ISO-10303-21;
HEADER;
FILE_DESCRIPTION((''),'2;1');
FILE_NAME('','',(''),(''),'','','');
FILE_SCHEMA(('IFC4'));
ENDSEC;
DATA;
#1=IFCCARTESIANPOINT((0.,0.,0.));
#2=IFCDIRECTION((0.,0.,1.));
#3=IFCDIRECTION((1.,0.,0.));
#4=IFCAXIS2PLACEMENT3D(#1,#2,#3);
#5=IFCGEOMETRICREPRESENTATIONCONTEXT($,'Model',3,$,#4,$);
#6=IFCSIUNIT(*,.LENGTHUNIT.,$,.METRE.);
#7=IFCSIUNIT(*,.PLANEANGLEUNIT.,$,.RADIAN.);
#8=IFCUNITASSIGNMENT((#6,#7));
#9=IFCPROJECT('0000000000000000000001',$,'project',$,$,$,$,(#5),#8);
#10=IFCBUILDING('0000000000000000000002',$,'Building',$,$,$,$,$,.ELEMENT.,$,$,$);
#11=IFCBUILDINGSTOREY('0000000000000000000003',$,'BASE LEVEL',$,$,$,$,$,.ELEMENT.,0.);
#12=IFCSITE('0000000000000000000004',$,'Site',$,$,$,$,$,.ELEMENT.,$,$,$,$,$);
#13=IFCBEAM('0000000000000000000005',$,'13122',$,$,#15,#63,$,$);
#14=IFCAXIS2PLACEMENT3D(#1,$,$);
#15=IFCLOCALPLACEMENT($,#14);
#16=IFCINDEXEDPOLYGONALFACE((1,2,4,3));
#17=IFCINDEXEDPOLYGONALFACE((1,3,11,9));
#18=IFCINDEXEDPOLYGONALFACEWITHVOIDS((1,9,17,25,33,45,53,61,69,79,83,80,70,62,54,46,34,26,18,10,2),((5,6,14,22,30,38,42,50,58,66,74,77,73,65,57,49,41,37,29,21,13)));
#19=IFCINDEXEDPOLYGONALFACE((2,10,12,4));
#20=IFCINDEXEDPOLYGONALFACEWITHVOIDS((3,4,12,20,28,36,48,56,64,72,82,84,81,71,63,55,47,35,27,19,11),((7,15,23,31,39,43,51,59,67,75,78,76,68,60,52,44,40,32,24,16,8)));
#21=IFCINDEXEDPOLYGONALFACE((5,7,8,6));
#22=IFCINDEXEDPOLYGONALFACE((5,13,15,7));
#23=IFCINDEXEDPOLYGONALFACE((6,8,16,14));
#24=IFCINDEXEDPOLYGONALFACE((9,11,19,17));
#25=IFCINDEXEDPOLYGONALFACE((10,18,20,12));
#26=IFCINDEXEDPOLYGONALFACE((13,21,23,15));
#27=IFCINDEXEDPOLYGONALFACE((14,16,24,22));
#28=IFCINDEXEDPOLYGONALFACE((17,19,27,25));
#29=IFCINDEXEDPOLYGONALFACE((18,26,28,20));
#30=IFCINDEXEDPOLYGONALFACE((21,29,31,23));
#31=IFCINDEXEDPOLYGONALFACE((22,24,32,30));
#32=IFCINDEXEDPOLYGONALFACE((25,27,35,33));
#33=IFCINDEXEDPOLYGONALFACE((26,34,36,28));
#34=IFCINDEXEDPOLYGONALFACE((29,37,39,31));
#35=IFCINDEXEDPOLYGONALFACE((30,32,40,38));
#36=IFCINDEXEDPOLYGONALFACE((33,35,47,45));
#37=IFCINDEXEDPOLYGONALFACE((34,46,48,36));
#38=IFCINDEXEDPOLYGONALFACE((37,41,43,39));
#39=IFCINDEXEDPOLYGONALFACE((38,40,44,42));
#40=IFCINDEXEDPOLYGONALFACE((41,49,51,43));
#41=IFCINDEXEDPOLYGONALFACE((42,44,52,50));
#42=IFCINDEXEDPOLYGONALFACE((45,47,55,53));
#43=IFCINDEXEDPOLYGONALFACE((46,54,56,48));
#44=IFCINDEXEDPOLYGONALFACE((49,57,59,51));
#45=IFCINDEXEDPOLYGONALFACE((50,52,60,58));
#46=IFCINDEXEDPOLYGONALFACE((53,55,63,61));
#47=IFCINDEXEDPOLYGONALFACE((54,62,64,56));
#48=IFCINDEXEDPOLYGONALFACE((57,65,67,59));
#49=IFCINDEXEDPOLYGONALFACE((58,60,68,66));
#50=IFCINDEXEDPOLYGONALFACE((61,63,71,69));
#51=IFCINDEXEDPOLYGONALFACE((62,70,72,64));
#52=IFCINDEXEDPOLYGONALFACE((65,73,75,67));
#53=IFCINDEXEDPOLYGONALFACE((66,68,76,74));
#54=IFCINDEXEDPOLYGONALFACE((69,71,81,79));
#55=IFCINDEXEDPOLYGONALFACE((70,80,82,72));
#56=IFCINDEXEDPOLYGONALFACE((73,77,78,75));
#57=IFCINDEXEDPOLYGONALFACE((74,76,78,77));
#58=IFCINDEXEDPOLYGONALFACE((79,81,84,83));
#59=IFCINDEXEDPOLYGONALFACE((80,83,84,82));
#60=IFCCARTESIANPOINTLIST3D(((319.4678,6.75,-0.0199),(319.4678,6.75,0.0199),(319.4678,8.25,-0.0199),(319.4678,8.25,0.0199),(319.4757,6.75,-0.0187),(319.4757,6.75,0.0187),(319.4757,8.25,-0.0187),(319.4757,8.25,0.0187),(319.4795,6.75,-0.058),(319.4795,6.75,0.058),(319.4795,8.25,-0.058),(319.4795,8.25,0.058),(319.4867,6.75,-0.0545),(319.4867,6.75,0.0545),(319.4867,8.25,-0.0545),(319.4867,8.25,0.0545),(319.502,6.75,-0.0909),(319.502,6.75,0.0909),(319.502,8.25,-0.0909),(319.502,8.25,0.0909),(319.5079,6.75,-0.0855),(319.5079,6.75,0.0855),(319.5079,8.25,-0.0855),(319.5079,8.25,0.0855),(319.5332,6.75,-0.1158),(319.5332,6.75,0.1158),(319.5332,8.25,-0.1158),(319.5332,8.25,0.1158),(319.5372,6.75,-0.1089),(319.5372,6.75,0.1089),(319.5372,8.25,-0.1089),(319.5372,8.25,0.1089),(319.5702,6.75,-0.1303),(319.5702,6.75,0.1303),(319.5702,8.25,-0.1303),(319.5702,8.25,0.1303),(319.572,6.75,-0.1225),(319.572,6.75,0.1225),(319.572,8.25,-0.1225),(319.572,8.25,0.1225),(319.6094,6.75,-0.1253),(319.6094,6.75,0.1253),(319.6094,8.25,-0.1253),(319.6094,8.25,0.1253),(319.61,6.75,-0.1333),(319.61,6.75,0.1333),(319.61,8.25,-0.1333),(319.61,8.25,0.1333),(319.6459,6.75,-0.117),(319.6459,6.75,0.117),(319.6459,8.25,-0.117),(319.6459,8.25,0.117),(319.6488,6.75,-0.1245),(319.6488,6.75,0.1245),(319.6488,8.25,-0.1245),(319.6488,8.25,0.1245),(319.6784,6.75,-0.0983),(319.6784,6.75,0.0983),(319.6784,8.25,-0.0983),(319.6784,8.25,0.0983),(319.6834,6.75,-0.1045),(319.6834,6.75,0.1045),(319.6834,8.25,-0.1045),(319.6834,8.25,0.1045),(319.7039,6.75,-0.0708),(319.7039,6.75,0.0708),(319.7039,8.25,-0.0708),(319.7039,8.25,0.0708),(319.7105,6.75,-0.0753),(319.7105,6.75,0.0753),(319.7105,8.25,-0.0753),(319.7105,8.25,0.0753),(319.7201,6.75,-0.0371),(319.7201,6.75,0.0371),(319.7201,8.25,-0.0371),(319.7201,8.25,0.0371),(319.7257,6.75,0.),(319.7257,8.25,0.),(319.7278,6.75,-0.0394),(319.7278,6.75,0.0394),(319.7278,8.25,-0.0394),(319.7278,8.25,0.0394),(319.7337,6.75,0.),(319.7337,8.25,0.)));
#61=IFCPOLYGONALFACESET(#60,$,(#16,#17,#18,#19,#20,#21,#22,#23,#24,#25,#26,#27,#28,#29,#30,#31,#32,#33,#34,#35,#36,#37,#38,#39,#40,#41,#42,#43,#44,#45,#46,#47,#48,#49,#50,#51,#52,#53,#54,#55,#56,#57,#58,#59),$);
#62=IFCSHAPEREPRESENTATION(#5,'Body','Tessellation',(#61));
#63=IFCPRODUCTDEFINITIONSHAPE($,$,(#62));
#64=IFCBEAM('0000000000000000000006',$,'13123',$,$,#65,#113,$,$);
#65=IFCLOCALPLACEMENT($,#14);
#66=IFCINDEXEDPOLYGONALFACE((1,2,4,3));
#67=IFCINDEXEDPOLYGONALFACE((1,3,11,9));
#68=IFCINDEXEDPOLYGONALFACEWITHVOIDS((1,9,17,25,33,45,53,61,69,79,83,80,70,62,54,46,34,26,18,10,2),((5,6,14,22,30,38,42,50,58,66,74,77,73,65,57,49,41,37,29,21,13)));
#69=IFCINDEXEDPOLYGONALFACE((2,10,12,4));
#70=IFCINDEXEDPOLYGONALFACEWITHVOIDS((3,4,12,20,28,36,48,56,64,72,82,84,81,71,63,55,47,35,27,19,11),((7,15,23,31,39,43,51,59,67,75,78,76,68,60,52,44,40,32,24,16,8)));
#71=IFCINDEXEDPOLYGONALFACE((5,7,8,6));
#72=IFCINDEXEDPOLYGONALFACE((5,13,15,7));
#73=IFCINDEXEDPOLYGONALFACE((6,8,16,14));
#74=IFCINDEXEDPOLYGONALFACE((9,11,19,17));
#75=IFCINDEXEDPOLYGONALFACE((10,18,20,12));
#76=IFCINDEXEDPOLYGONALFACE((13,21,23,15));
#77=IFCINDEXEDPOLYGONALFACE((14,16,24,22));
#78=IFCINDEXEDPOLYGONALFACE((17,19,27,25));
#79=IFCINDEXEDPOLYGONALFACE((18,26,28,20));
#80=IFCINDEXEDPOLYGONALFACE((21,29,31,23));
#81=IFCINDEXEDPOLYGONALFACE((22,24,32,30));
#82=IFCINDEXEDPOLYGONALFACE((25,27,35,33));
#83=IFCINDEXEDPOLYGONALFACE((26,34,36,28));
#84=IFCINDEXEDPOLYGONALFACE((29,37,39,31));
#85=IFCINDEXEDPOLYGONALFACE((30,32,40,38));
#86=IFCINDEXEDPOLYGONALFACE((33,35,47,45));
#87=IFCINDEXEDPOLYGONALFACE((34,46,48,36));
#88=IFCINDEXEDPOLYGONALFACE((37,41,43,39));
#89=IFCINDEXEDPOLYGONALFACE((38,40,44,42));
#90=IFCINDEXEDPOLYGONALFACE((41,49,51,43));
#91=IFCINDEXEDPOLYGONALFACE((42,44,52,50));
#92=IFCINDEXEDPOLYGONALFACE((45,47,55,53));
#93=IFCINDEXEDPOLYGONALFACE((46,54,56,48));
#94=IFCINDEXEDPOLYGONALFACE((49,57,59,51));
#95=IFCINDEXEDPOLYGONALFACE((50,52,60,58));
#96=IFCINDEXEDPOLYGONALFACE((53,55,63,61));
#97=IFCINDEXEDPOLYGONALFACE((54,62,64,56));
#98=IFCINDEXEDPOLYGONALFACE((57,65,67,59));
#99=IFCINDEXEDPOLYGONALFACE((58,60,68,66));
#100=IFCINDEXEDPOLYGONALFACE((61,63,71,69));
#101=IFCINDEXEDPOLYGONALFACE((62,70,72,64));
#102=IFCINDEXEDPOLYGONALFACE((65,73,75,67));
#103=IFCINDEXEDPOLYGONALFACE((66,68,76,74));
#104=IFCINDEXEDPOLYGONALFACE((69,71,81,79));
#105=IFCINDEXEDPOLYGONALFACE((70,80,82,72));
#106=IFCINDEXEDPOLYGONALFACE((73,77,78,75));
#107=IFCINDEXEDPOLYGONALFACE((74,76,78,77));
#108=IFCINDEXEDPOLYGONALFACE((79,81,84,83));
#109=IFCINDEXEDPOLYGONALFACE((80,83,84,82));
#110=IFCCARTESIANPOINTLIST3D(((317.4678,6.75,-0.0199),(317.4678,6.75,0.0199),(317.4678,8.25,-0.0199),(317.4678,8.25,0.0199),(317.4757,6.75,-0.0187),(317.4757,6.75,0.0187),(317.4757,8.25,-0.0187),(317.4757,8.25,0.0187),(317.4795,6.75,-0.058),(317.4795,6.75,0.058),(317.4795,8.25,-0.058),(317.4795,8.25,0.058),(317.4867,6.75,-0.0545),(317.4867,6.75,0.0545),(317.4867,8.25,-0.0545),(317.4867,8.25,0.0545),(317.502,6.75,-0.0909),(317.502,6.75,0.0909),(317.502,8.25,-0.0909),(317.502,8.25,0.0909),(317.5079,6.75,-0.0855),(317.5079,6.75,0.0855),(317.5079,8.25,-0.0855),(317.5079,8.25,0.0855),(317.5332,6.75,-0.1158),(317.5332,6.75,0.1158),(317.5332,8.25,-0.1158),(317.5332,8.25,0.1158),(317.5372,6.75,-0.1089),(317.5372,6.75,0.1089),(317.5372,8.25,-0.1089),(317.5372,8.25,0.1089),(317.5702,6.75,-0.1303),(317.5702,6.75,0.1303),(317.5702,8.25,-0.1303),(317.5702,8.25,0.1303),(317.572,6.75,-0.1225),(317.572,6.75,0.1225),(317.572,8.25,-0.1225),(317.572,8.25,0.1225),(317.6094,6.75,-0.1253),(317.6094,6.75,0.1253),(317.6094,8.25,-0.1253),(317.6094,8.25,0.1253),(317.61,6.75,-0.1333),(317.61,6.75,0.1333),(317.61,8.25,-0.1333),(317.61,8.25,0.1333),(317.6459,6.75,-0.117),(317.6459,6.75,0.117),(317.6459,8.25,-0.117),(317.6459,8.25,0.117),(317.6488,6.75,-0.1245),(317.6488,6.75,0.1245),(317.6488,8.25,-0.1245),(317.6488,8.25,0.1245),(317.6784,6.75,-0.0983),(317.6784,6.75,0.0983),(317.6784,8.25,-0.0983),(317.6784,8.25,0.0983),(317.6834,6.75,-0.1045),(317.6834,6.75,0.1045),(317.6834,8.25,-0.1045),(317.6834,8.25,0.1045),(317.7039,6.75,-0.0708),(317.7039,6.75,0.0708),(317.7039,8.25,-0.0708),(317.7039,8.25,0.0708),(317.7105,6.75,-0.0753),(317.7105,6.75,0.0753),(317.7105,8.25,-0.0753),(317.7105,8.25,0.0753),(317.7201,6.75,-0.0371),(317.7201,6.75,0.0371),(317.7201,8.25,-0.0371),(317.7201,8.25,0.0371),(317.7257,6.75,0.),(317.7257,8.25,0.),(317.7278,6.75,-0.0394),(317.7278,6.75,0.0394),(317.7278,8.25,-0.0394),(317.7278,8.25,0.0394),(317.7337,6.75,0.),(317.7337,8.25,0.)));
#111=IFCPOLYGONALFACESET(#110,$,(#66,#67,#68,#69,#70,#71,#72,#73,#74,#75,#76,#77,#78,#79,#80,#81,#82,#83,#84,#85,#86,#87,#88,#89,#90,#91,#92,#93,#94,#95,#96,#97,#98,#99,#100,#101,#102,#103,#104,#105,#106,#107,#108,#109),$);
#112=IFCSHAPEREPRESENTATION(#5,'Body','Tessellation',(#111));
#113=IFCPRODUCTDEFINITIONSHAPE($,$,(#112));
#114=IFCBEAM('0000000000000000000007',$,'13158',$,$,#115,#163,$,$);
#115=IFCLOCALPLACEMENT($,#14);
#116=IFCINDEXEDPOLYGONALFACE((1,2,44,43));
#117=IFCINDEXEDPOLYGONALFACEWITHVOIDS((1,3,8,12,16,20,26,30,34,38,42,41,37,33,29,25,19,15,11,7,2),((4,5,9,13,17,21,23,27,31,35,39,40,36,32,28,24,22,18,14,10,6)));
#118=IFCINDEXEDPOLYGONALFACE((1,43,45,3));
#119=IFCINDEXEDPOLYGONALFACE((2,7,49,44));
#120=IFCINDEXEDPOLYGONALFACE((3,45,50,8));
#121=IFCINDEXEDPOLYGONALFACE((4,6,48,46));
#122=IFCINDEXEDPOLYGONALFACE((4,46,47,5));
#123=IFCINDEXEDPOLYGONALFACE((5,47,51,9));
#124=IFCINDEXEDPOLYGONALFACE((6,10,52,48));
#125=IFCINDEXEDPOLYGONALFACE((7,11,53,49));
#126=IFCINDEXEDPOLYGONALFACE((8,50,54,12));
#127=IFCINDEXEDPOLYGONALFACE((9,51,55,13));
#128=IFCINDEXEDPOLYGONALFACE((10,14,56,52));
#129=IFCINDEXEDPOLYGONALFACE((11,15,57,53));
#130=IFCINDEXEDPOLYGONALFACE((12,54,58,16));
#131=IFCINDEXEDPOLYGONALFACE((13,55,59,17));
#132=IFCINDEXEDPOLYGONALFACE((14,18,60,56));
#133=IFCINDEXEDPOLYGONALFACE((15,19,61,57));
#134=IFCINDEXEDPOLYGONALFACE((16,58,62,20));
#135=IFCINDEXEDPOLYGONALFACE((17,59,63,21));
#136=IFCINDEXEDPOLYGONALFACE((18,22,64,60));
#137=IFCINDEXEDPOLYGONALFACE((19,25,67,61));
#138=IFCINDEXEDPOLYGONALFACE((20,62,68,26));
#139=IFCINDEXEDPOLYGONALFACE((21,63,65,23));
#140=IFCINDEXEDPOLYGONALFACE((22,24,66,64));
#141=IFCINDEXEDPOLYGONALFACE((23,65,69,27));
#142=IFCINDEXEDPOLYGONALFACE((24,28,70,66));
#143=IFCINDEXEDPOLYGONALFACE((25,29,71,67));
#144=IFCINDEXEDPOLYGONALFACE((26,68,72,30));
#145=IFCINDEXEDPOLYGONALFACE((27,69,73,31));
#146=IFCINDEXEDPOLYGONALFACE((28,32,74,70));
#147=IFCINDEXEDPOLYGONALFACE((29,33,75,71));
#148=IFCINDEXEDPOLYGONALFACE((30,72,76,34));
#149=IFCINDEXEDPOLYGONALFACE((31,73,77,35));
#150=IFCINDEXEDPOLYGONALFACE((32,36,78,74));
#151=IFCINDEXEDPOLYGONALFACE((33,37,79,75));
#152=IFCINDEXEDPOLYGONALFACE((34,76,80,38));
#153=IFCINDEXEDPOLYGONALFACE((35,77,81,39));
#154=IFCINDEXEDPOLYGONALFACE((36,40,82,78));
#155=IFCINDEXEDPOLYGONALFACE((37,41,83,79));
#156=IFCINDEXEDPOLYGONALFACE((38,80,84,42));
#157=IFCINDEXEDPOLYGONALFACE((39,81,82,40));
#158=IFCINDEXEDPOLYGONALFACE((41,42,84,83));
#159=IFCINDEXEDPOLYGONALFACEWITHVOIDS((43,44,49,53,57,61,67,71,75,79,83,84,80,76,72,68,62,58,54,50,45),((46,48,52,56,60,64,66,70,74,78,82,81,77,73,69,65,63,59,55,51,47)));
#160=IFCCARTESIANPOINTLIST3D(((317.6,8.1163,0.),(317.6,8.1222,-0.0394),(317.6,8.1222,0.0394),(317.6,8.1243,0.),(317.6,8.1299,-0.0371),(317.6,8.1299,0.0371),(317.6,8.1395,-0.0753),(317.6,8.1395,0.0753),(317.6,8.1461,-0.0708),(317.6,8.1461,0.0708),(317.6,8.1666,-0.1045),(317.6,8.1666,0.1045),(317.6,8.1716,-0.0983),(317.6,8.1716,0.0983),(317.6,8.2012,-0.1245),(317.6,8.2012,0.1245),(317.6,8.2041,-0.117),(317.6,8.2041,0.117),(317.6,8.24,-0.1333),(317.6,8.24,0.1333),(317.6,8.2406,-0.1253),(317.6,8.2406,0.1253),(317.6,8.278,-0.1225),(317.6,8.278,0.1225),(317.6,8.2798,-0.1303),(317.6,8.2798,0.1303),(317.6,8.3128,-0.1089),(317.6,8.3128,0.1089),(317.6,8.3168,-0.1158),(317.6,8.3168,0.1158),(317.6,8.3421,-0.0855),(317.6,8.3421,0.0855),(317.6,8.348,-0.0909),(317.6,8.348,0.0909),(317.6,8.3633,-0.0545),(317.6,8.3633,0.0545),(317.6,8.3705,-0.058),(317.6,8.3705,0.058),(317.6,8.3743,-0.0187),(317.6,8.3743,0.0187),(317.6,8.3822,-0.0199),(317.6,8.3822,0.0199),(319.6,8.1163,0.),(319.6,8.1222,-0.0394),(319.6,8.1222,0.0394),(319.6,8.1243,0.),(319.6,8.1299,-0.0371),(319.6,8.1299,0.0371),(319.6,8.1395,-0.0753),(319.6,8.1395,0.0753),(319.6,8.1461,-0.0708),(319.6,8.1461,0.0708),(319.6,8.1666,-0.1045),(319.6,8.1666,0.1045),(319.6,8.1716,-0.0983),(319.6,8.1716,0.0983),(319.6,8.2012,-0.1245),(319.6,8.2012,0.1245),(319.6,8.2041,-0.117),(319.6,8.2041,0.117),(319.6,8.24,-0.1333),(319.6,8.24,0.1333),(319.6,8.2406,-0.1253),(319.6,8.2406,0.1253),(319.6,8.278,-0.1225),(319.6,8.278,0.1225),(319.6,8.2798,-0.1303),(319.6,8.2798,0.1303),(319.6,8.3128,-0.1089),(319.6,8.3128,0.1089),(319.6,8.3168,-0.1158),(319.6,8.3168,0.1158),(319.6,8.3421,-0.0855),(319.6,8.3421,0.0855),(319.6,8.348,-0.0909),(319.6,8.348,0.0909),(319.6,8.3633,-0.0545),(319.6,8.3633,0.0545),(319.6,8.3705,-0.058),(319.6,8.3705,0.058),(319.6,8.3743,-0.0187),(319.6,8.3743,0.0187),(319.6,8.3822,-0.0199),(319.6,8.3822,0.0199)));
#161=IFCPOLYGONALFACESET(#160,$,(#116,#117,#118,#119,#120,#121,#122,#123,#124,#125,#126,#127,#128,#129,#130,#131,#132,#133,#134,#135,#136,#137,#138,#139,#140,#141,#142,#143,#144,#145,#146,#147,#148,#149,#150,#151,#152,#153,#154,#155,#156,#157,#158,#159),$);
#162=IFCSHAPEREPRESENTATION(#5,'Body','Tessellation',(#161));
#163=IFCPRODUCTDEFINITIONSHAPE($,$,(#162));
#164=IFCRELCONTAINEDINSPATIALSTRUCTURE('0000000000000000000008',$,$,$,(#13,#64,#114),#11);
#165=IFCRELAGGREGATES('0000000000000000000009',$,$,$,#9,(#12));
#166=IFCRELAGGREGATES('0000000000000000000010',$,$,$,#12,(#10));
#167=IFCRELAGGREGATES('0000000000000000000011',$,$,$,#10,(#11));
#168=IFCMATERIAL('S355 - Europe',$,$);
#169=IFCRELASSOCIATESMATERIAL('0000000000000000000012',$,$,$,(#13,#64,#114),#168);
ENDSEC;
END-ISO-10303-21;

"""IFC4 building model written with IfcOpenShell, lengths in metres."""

from ifc_helpers import new_model, si_unit, frame, origin_with_axes, origin_2d_with_axis, place, context, project, spatial, hollow_circle, extrude, material, material_profile, profile_set, profile_usage, element, save


model = new_model("IFC4")

# Units and contexts
model_context = context("Model", 3, world=origin_with_axes())
ifc_project = project(units=[si_unit("LENGTHUNIT", "METRE"), si_unit("PLANEANGLEUNIT", "RADIAN")], contexts=[model_context])

# Site, building, storey
site = spatial("IfcSite", under=ifc_project, Name="Site", CompositionType="ELEMENT")
building = spatial("IfcBuilding", under=site, Name="Building", CompositionType="ELEMENT")
storey = spatial("IfcBuildingStorey", under=building, Name="BASE LEVEL", CompositionType="ELEMENT", Elevation=0.0)

# Shared definitions
ifc_material = material(Name="S355 - Europe")

# Beams
ifc_material_profile_1 = material_profile(ifc_material, hollow_circle(Radius=0.1337, WallThickness=0.008, at=origin_2d_with_axis()))
ifc_profile_set_1 = profile_set([ifc_material_profile_1])
ifc_profile_usage_1 = profile_usage(ifc_profile_set_1, cardinal=10)
beam_1_placement = place(None, frame((319.6, 8.25, 0.0), z_axis=(0.0, -1.0, 0.0), x_axis=(1.0, 0.0, 0.0)))
element("IfcBeam", 1, at=beam_1_placement, inside=storey, material=ifc_profile_usage_1, Name="13122", context=model_context, shape_type="SweptSolid", body=[
    extrude(hollow_circle(Radius=0.1337, WallThickness=0.008, at=origin_2d_with_axis()), origin_with_axes(), (0.0, 0.0, 1.0), 1.5),
])
ifc_material_profile_2 = material_profile(ifc_material, hollow_circle(Radius=0.1337, WallThickness=0.008, at=origin_2d_with_axis()))
ifc_profile_set_2 = profile_set([ifc_material_profile_2])
ifc_profile_usage_2 = profile_usage(ifc_profile_set_2, cardinal=10)
beam_2_placement = place(None, frame((317.6, 8.25, 0.0), z_axis=(0.0, -1.0, 0.0), x_axis=(1.0, 0.0, 0.0)))
element("IfcBeam", 2, at=beam_2_placement, inside=storey, material=ifc_profile_usage_2, Name="13123", context=model_context, shape_type="SweptSolid", body=[
    extrude(hollow_circle(Radius=0.1337, WallThickness=0.008, at=origin_2d_with_axis()), origin_with_axes(), (0.0, 0.0, 1.0), 1.5),
])
ifc_material_profile_3 = material_profile(ifc_material, hollow_circle(Radius=0.1337, WallThickness=0.008, at=origin_2d_with_axis()))
ifc_profile_set_3 = profile_set([ifc_material_profile_3])
ifc_profile_usage_3 = profile_usage(ifc_profile_set_3, cardinal=10)
beam_3_placement = place(None, frame((319.6, 8.25, 0.0), z_axis=(-1.0, 0.0, 0.0), x_axis=(0.0, -1.0, 0.0)))
element("IfcBeam", 3, at=beam_3_placement, inside=storey, material=ifc_profile_usage_3, Name="13158", context=model_context, shape_type="SweptSolid", body=[
    extrude(hollow_circle(Radius=0.1337, WallThickness=0.008, at=origin_2d_with_axis()), origin_with_axes(), (0.0, 0.0, 1.0), 2.0),
])

save(model, "model.ifc")
